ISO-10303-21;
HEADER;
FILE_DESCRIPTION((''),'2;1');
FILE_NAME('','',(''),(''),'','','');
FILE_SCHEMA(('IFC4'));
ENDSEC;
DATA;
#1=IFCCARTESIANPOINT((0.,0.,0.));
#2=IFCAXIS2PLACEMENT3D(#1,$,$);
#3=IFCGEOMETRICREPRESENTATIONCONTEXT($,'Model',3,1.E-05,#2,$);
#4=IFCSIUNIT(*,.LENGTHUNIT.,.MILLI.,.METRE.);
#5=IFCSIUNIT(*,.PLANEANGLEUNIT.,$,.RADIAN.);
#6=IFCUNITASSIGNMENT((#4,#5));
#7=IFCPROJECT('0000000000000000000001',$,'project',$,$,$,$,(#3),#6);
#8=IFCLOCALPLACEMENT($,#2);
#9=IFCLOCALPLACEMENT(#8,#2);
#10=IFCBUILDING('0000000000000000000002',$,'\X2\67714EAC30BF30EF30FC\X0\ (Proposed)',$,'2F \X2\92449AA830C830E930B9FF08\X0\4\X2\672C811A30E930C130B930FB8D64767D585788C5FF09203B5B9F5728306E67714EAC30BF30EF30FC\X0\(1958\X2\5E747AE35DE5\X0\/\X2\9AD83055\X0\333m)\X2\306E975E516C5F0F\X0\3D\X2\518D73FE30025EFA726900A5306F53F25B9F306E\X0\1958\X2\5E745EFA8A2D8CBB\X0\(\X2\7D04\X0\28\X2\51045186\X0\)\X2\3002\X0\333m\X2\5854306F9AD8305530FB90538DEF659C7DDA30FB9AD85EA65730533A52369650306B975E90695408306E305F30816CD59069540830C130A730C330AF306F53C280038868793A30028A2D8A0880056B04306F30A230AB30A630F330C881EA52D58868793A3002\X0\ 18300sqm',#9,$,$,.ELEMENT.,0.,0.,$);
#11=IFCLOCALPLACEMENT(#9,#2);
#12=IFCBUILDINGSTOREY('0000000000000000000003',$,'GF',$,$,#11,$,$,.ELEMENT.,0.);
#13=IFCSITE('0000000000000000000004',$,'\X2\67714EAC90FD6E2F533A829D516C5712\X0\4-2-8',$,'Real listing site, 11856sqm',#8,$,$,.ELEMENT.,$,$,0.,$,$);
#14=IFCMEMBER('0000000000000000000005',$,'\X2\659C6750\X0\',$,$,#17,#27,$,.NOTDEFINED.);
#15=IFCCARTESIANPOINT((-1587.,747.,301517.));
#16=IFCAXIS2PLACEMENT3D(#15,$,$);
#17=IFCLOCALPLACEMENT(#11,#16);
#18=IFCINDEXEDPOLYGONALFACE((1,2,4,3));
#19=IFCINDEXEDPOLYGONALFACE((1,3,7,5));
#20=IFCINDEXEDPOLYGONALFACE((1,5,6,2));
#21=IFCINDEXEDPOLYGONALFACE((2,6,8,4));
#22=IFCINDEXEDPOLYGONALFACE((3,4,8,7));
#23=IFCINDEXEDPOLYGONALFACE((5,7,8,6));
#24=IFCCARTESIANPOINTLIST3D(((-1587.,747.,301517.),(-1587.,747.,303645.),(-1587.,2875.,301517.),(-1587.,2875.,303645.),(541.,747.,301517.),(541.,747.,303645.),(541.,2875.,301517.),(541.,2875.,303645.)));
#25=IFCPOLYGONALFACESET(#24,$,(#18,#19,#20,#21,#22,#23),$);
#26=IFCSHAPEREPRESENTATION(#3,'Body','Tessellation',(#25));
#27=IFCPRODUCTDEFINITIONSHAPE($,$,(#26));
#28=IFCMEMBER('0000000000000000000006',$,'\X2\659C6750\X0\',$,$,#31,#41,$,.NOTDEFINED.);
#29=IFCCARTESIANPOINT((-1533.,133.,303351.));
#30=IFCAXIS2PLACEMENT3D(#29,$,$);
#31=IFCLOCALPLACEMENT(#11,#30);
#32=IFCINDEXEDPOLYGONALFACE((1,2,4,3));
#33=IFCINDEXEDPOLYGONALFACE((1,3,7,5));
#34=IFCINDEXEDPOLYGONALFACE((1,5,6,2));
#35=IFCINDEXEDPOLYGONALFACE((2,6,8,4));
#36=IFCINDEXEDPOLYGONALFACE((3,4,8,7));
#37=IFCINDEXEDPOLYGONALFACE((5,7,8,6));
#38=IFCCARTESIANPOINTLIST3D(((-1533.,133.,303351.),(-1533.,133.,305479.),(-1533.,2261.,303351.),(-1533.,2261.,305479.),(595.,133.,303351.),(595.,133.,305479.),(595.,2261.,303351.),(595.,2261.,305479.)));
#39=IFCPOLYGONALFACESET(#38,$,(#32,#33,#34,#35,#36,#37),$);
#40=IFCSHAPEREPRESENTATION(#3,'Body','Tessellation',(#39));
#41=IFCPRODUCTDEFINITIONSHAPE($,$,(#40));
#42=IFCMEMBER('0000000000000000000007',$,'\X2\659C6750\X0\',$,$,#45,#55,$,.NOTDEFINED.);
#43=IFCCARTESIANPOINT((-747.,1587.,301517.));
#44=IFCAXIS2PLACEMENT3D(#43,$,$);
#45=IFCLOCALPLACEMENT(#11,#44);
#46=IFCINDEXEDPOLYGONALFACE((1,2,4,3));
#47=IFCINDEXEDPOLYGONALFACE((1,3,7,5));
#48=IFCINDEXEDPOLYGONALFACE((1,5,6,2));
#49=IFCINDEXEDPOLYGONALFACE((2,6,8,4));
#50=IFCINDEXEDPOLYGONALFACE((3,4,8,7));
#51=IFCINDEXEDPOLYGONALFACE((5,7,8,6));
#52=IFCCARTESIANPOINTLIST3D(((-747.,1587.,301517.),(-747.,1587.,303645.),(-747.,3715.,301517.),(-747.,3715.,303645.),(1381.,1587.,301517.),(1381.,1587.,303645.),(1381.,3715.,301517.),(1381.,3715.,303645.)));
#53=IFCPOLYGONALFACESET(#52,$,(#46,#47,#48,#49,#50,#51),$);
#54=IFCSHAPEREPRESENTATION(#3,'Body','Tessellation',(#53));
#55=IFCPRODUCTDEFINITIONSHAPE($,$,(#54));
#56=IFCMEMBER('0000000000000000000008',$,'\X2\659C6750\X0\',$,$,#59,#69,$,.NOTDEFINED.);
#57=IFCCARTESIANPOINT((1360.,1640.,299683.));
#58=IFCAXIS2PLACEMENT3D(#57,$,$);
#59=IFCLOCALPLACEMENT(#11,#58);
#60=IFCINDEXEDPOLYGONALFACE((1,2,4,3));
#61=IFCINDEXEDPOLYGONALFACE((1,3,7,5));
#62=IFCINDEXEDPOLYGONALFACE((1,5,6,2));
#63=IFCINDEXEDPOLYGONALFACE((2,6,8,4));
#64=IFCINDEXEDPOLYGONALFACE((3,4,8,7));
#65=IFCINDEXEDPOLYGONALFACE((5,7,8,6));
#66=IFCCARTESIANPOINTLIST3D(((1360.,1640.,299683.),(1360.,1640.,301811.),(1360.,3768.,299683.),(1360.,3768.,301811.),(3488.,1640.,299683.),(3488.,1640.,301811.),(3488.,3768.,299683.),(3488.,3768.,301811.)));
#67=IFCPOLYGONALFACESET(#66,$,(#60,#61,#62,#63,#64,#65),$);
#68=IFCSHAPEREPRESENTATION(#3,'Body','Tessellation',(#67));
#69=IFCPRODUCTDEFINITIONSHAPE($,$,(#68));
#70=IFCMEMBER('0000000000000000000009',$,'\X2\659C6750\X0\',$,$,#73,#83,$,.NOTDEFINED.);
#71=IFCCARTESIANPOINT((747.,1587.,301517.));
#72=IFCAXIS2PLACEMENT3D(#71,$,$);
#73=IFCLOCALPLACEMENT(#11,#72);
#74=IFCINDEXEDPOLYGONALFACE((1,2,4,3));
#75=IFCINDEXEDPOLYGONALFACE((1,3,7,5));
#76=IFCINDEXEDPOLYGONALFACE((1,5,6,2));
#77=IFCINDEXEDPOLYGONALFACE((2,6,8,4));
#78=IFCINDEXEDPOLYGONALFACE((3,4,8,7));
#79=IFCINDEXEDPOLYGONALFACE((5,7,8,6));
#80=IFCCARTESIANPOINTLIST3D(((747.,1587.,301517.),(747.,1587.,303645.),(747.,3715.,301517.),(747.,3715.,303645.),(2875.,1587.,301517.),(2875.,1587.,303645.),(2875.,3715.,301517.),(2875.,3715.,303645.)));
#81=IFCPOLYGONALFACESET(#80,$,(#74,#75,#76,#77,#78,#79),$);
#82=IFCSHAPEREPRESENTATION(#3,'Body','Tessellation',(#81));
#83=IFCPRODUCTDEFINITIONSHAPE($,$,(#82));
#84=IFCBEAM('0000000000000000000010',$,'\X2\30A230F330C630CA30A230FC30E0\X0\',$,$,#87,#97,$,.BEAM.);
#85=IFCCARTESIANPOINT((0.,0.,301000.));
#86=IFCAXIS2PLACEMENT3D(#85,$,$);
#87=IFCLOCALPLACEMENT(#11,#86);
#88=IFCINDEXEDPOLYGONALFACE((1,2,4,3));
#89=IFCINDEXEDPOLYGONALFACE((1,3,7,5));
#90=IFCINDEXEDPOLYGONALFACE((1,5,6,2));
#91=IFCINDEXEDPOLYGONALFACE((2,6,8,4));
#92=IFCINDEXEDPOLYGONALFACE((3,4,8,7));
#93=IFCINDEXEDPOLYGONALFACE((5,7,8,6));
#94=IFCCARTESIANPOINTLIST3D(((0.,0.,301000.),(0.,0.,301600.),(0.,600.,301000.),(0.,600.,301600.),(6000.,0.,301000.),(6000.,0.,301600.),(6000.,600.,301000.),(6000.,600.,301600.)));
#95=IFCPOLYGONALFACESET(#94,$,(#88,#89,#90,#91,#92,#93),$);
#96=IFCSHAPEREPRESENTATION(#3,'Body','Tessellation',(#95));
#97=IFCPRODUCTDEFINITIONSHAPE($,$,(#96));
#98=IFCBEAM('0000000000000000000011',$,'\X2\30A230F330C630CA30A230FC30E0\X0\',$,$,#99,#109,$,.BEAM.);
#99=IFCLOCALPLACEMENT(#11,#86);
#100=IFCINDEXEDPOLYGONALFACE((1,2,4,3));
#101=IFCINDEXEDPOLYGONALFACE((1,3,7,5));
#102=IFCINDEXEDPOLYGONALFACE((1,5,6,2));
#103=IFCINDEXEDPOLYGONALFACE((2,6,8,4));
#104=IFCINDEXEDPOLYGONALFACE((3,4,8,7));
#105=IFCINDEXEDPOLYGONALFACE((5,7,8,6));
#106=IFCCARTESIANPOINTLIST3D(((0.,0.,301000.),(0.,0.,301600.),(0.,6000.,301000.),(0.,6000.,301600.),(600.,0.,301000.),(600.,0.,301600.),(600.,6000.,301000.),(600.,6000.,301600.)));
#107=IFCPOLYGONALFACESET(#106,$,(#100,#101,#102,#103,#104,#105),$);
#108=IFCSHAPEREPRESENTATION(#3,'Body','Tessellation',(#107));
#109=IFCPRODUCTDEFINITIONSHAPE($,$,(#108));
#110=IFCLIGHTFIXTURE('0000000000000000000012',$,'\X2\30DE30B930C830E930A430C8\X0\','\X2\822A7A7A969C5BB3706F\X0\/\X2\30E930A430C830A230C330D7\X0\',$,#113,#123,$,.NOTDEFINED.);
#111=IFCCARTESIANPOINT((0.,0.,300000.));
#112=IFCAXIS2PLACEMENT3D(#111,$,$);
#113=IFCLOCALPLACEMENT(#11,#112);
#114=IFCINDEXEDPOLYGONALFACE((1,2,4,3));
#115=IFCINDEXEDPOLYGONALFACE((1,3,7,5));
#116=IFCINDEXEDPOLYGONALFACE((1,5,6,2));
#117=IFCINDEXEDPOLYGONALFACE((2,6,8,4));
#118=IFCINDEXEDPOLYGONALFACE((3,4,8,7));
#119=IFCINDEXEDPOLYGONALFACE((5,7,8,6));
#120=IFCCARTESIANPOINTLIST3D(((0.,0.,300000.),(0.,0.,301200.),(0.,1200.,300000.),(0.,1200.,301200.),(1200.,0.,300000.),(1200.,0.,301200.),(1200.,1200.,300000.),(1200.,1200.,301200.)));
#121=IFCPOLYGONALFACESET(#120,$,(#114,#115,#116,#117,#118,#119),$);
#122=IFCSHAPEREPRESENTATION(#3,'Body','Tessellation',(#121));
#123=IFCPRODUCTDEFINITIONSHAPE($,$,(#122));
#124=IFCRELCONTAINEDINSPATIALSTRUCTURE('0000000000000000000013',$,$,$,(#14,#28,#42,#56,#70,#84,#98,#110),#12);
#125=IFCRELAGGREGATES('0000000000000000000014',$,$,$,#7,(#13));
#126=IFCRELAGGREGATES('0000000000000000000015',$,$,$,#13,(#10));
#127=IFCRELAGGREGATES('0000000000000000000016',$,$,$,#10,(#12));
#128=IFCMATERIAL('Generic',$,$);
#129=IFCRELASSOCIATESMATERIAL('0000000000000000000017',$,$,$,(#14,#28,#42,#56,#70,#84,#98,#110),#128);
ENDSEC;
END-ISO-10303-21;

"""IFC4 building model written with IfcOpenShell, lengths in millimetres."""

from ifc_helpers import new_model, si_unit, frame, frame_2d, origin, place, context, project, spatial, rectangle, extrude, material, element, save


model = new_model("IFC4")

# Units and contexts
model_context = context("Model", 3, precision=1e-05, world=origin())
ifc_project = project(units=[si_unit("LENGTHUNIT", "METRE", prefix="MILLI"), si_unit("PLANEANGLEUNIT", "RADIAN")], contexts=[model_context])

# Site, building, storey
site_placement = place(None, origin())
site = spatial("IfcSite", under=ifc_project, at=site_placement, Name="東京都港区芝公園4-2-8", ObjectType="Real listing site, 11856sqm", CompositionType="ELEMENT", RefElevation=0.0)
building_placement = place(site_placement, origin())
building = spatial("IfcBuilding", under=site, at=building_placement, Name="東京タワー (Proposed)", ObjectType="2F 鉄骨トラス（4本脚ラチス・赤白塗装）※実在の東京タワー(1958年竣工/高さ333m)の非公式3D再現。建物¥は史実の1958年建設費(約28億円)。333m塔は高さ・道路斜線・高度地区制限に非適合のため法適合チェックは参考表示。設計者欄はアカウント自動表示。 18300sqm", CompositionType="ELEMENT", ElevationOfRefHeight=0.0, ElevationOfTerrain=0.0)
storey_placement = place(building_placement, origin())
storey = spatial("IfcBuildingStorey", under=building, at=storey_placement, Name="GF", CompositionType="ELEMENT", Elevation=0.0)

# Shared definitions
ifc_material = material(Name="Generic")

# Members
member_1_placement = place(storey_placement, frame((-1587.0, 747.0, 301517.0)))
element("IfcMember", 1, at=member_1_placement, inside=storey, material=ifc_material, Name="斜材", PredefinedType="NOTDEFINED", context=model_context, shape_type="SweptSolid", body=[
    extrude(rectangle(XDim=2128.0, YDim=2128.0, at=frame_2d((1064.0, 1064.0))), frame((-1587.0, 747.0, 301517.0)), (0.0, 0.0, 1.0), 2128.0),
])
member_2_placement = place(storey_placement, frame((-1533.0, 133.0, 303351.0)))
element("IfcMember", 2, at=member_2_placement, inside=storey, material=ifc_material, Name="斜材", PredefinedType="NOTDEFINED", context=model_context, shape_type="SweptSolid", body=[
    extrude(rectangle(XDim=2128.0, YDim=2128.0, at=frame_2d((1064.0, 1064.0))), frame((-1533.0, 133.0, 303351.0)), (0.0, 0.0, 1.0), 2128.0),
])
member_3_placement = place(storey_placement, frame((-747.0, 1587.0, 301517.0)))
element("IfcMember", 3, at=member_3_placement, inside=storey, material=ifc_material, Name="斜材", PredefinedType="NOTDEFINED", context=model_context, shape_type="SweptSolid", body=[
    extrude(rectangle(XDim=2128.0, YDim=2128.0, at=frame_2d((1064.0, 1064.0))), frame((-747.0, 1587.0, 301517.0)), (0.0, 0.0, 1.0), 2128.0),
])
member_4_placement = place(storey_placement, frame((1360.0, 1640.0, 299683.0)))
element("IfcMember", 4, at=member_4_placement, inside=storey, material=ifc_material, Name="斜材", PredefinedType="NOTDEFINED", context=model_context, shape_type="SweptSolid", body=[
    extrude(rectangle(XDim=2128.0, YDim=2128.0, at=frame_2d((1064.0, 1064.0))), frame((1360.0, 1640.0, 299683.0)), (0.0, 0.0, 1.0), 2128.0),
])
member_5_placement = place(storey_placement, frame((747.0, 1587.0, 301517.0)))
element("IfcMember", 5, at=member_5_placement, inside=storey, material=ifc_material, Name="斜材", PredefinedType="NOTDEFINED", context=model_context, shape_type="SweptSolid", body=[
    extrude(rectangle(XDim=2128.0, YDim=2128.0, at=frame_2d((1064.0, 1064.0))), frame((747.0, 1587.0, 301517.0)), (0.0, 0.0, 1.0), 2128.0),
])

# Beams
beam_1_placement = place(storey_placement, frame((0.0, 0.0, 301000.0)))
element("IfcBeam", 6, at=beam_1_placement, inside=storey, material=ifc_material, Name="アンテナアーム", PredefinedType="BEAM", context=model_context, shape_type="SweptSolid", body=[
    extrude(rectangle(XDim=6000.0, YDim=600.0, at=frame_2d((3000.0, 300.0))), frame((0.0, 0.0, 301000.0)), (0.0, 0.0, 1.0), 600.0),
])
beam_2_placement = place(storey_placement, frame((0.0, 0.0, 301000.0)))
element("IfcBeam", 7, at=beam_2_placement, inside=storey, material=ifc_material, Name="アンテナアーム", PredefinedType="BEAM", context=model_context, shape_type="SweptSolid", body=[
    extrude(rectangle(XDim=600.0, YDim=6000.0, at=frame_2d((300.0, 3000.0))), frame((0.0, 0.0, 301000.0)), (0.0, 0.0, 1.0), 600.0),
])

# Light fixture
light_fixture_placement = place(storey_placement, frame((0.0, 0.0, 300000.0)))
element("IfcLightFixture", 8, at=light_fixture_placement, inside=storey, material=ifc_material, Name="マストライト", Description="航空障害灯/ライトアップ", PredefinedType="NOTDEFINED", context=model_context, shape_type="SweptSolid", body=[
    extrude(rectangle(XDim=1200.0, YDim=1200.0, at=frame_2d((600.0, 600.0))), frame((0.0, 0.0, 300000.0)), (0.0, 0.0, 1.0), 1200.0),
])

save(model, "model.ifc")
